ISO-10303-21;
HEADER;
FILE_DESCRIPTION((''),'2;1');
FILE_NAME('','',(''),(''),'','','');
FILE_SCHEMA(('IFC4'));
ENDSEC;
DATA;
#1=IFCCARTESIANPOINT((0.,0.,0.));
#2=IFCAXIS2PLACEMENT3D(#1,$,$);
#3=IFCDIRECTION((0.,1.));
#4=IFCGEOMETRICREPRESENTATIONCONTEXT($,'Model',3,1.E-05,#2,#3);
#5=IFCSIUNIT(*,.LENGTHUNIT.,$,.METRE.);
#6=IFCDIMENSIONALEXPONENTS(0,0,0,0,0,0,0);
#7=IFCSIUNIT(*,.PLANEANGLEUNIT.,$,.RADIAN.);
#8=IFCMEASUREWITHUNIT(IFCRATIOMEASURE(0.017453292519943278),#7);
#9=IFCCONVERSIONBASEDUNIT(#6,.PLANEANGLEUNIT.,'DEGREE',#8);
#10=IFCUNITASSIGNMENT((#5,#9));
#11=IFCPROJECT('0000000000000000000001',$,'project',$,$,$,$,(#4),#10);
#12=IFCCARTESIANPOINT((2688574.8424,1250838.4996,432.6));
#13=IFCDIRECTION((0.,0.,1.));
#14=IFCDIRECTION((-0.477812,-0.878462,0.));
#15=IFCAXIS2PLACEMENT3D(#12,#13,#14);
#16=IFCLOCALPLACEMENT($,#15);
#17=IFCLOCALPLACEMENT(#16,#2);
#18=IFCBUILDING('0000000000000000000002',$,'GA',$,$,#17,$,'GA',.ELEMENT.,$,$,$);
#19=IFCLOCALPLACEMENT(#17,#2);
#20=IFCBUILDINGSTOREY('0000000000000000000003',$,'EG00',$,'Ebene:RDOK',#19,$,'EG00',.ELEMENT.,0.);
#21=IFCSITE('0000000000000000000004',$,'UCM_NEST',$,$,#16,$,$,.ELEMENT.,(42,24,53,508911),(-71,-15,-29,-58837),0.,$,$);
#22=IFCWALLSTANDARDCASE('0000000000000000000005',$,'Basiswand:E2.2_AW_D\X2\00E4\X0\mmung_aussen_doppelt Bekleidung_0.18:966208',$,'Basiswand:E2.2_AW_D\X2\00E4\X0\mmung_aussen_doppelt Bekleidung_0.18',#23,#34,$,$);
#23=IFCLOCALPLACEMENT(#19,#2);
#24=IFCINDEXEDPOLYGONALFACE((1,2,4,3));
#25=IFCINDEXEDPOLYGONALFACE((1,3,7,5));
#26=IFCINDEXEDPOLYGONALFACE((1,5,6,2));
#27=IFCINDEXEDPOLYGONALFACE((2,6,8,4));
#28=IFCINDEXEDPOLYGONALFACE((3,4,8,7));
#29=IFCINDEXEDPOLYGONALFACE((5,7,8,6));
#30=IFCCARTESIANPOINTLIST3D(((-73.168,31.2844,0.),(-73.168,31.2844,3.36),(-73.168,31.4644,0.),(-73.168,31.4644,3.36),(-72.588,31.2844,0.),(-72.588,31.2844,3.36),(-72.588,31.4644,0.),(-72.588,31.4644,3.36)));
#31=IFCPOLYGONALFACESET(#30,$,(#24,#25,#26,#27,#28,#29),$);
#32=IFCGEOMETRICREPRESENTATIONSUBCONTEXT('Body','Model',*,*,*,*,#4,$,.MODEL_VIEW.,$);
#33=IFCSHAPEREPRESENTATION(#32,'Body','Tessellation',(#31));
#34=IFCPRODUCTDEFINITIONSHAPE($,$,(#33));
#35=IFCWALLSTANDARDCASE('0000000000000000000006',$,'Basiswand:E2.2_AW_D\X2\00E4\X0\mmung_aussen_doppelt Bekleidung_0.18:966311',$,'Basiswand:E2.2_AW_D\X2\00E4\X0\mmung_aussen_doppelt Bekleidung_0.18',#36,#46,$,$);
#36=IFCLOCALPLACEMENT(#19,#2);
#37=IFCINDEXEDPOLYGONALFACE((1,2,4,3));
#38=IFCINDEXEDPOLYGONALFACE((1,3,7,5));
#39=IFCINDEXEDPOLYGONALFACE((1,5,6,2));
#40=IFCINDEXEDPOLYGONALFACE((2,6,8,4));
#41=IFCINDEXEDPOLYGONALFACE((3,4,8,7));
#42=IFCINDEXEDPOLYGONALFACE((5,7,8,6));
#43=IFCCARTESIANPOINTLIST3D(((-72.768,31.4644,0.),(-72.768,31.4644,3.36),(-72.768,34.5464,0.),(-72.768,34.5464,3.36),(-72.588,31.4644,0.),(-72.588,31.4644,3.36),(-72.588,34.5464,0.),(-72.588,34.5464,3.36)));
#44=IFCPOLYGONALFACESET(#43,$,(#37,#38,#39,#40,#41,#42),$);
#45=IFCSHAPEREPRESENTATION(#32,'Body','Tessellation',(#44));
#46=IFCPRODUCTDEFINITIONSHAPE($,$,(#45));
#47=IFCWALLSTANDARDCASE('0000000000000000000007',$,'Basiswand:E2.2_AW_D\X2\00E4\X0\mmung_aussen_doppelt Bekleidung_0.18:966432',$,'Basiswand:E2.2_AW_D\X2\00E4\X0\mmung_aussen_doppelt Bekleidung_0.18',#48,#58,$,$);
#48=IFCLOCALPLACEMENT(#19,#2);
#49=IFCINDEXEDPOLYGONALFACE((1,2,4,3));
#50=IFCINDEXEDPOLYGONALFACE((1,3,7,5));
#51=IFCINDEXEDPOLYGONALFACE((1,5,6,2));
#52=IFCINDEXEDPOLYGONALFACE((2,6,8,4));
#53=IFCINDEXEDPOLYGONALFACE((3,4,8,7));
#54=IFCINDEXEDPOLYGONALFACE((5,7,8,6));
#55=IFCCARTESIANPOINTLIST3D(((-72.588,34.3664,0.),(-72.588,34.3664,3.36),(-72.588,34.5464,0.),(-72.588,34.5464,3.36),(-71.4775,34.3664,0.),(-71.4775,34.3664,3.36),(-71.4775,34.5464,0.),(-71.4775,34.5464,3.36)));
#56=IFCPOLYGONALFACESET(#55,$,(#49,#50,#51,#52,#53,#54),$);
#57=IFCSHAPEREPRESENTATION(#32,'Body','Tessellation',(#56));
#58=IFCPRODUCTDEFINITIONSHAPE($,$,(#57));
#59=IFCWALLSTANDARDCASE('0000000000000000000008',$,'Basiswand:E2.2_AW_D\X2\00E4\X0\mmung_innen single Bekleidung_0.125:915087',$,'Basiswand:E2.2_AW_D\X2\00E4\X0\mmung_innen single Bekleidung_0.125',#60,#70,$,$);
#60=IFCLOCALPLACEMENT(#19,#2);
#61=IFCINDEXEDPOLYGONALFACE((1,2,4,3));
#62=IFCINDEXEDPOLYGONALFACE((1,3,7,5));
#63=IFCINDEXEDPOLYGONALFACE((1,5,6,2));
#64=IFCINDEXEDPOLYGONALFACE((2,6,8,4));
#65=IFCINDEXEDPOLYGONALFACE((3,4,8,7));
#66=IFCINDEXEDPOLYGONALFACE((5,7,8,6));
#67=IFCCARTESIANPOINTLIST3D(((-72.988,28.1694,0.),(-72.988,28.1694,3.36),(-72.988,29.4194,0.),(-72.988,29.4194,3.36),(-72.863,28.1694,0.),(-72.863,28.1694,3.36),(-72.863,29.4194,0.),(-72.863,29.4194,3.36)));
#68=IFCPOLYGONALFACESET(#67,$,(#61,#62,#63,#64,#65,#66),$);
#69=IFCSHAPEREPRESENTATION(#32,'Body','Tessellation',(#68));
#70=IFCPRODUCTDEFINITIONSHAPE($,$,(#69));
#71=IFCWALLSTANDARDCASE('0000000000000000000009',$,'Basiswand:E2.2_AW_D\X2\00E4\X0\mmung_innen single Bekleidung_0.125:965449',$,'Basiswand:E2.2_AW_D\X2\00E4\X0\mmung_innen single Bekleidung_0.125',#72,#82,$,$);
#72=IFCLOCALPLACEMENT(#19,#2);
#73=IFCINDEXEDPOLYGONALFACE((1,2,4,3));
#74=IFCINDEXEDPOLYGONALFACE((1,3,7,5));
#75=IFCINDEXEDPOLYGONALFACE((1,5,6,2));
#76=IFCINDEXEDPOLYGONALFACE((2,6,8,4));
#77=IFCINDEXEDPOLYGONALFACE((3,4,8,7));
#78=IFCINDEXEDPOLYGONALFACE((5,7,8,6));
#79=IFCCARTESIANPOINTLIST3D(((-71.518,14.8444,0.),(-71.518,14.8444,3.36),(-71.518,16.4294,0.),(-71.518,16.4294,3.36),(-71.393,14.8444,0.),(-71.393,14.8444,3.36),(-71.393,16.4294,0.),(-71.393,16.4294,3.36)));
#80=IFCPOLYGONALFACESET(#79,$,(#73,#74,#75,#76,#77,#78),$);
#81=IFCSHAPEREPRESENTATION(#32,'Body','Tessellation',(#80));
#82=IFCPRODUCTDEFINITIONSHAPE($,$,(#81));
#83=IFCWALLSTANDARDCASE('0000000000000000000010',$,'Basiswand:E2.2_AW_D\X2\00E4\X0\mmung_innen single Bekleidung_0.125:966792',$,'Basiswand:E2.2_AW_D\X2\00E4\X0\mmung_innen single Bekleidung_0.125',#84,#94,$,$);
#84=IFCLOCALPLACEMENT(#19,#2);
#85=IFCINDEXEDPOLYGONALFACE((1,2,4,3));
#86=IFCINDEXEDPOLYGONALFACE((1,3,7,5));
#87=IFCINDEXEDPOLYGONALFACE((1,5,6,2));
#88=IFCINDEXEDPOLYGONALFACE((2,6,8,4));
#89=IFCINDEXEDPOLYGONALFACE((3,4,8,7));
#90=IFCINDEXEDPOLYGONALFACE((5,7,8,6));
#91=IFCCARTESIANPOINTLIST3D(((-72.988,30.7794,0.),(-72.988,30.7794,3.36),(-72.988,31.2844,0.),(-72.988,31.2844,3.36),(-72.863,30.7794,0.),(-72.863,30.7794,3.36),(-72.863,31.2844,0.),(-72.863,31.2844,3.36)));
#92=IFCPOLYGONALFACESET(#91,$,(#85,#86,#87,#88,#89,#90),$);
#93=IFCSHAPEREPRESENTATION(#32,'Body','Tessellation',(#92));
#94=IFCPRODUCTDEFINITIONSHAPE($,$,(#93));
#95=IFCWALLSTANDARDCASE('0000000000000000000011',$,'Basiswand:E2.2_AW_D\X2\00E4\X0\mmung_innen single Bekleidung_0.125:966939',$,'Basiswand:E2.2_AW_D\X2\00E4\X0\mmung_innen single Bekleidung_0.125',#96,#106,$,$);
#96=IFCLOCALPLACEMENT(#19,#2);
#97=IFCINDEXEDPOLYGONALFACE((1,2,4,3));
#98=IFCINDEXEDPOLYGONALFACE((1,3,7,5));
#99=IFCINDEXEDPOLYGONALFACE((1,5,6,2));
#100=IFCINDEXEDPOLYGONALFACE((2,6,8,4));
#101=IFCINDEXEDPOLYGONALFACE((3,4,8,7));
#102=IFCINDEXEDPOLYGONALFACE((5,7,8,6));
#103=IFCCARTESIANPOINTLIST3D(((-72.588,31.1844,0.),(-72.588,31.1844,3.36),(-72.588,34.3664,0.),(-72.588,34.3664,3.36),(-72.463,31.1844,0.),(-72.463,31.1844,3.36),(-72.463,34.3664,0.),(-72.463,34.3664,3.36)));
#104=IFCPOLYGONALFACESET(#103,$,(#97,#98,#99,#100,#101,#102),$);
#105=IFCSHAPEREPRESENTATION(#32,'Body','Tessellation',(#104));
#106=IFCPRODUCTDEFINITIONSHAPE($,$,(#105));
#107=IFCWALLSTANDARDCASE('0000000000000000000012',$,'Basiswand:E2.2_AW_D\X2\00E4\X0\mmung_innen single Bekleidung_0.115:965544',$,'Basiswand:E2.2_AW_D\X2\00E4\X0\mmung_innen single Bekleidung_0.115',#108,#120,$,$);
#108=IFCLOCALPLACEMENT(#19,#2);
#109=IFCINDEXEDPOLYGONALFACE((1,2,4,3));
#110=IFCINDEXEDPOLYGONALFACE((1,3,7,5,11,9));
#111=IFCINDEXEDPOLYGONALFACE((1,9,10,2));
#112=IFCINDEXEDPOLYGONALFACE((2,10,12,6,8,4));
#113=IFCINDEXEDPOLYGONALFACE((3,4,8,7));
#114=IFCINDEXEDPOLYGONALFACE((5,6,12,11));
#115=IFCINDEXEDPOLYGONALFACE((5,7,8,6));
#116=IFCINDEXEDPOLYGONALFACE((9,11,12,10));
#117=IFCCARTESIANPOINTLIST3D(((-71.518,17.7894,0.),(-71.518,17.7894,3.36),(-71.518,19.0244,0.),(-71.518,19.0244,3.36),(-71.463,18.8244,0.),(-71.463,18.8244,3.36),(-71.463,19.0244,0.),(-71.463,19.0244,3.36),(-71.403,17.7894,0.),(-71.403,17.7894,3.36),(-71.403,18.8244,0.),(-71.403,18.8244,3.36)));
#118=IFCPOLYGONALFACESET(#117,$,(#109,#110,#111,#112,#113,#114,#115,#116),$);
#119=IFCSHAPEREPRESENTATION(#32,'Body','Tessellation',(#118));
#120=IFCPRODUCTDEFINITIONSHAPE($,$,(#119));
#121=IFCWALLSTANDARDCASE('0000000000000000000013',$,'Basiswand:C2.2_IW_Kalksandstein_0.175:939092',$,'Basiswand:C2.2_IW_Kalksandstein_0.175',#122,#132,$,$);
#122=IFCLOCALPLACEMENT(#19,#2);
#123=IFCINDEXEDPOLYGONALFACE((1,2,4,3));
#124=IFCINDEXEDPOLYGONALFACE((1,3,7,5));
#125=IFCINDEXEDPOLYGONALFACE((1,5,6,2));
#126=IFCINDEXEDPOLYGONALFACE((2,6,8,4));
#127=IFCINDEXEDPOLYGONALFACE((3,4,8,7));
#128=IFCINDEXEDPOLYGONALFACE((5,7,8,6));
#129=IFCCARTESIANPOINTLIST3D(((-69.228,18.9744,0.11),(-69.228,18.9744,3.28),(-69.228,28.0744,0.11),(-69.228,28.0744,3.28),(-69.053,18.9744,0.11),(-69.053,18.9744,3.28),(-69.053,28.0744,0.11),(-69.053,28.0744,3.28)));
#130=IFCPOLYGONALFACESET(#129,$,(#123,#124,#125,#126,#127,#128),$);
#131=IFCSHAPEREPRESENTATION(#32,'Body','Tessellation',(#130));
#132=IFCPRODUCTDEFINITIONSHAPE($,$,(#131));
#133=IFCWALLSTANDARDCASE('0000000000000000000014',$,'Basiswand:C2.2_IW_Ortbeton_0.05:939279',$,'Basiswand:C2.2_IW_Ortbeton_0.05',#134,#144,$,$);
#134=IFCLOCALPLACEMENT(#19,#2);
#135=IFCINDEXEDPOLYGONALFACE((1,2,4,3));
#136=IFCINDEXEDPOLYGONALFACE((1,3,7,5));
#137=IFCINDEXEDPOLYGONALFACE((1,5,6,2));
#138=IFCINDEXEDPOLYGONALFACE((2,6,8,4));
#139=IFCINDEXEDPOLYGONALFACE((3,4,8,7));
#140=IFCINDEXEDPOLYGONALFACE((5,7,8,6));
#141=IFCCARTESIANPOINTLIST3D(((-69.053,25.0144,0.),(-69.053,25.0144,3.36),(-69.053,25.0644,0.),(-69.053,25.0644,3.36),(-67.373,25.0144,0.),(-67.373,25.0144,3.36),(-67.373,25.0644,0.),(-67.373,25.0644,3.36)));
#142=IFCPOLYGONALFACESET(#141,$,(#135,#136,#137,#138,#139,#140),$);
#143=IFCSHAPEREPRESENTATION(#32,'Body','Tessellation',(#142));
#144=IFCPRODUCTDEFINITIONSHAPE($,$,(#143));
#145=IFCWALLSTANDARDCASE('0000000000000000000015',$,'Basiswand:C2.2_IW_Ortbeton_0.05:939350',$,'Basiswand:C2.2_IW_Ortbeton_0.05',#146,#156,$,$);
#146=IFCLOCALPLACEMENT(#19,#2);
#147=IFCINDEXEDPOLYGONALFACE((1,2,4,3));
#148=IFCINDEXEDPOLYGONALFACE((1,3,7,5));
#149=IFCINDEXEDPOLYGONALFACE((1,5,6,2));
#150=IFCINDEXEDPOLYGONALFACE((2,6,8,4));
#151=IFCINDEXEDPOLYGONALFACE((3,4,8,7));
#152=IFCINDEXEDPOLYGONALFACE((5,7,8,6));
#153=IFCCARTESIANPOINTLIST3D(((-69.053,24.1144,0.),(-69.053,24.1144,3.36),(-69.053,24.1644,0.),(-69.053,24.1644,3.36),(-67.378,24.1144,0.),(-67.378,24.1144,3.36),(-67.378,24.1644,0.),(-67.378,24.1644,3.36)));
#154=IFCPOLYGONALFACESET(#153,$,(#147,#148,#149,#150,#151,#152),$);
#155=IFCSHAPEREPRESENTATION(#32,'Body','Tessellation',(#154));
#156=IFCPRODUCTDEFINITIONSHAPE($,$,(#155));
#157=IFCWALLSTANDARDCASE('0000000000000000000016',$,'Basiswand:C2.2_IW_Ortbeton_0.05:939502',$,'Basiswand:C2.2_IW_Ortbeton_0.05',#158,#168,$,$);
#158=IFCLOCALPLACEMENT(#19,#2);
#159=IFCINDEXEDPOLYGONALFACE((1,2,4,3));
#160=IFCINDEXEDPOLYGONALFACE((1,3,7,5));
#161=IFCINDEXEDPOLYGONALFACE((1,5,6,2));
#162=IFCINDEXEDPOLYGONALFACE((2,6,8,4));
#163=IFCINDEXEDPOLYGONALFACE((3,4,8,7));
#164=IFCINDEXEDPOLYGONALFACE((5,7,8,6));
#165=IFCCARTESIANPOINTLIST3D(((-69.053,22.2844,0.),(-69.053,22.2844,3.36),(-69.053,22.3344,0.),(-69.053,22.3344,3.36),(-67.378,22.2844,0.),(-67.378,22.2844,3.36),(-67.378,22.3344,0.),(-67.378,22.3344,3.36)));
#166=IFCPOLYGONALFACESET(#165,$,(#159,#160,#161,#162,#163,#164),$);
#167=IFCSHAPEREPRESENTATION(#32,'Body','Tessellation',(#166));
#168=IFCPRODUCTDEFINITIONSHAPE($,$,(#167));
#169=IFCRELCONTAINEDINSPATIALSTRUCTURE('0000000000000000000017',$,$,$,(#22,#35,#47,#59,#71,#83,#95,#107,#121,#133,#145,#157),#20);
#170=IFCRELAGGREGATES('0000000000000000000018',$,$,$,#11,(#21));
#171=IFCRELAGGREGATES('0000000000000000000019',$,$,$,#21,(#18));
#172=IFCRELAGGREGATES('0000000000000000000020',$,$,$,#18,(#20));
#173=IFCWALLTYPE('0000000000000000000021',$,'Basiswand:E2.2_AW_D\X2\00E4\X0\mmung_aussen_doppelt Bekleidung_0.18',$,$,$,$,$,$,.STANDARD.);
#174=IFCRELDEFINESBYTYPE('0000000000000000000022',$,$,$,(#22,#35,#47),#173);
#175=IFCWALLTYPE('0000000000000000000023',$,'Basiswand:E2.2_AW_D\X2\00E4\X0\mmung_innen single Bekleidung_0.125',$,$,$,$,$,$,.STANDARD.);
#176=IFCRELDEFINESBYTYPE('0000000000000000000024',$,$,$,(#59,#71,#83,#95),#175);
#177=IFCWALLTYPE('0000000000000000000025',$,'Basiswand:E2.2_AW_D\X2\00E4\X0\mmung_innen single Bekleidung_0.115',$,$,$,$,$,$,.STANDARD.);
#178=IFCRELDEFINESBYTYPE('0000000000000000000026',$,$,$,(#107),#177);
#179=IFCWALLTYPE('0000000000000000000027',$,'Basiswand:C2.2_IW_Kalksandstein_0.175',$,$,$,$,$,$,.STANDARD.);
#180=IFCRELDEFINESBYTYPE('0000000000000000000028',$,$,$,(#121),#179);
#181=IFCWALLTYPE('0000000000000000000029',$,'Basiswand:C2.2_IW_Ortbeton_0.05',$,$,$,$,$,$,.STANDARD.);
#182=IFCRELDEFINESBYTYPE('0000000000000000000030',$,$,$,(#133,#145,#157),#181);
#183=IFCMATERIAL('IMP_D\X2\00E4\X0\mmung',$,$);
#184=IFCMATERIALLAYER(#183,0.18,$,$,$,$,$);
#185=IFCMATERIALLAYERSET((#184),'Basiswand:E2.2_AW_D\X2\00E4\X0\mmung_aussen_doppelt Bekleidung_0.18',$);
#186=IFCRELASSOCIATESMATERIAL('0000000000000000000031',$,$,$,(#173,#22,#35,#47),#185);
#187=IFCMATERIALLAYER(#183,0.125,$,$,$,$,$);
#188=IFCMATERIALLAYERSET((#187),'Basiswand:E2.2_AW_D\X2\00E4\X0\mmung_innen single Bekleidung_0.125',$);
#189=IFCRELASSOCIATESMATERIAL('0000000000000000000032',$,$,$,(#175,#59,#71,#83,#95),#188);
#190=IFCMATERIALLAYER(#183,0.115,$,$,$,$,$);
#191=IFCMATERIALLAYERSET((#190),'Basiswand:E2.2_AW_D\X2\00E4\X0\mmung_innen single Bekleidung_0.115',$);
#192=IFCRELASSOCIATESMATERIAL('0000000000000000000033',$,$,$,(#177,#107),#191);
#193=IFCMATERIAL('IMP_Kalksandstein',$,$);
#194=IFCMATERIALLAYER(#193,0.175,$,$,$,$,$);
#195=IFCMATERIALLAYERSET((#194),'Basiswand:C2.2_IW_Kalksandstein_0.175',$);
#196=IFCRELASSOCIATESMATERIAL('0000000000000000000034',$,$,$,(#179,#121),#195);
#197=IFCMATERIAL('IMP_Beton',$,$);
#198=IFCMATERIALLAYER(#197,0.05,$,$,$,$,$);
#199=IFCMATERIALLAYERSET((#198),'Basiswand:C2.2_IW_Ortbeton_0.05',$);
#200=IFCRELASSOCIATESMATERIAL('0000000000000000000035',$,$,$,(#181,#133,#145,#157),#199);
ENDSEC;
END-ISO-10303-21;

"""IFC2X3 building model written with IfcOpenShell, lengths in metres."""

from ifc_helpers import new_model, entity, si_unit, converted_unit, direction, frame, frame_2d, origin, place, context, subcontext, project, spatial, polyline, rectangle, extrude, clip, bounded_halfspace, material, layer, layer_set, layer_usage, type_object, element, save


model = new_model("IFC2X3")

# Units and contexts
model_context = context("Model", 3, precision=1e-05, world=origin(), true_north=direction((0.0, 1.0)))
body_context = subcontext(model_context, "Body", "Model", "MODEL_VIEW")
ifc_project = project(units=[si_unit("LENGTHUNIT", "METRE"), converted_unit("PLANEANGLEUNIT", "DEGREE", entity("IfcRatioMeasure", 0.017453292519943278), si_unit("PLANEANGLEUNIT", "RADIAN"), dimensions=[0, 0, 0, 0, 0, 0, 0])], contexts=[model_context])

# Site, building, storey
site_placement = place(None, frame((2688574.8424, 1250838.4996, 432.6), z_axis=(0.0, 0.0, 1.0), x_axis=(-0.477812, -0.878462, 0.0)))
site = spatial("IfcSite", under=ifc_project, at=site_placement, Name="UCM_NEST", CompositionType="ELEMENT", RefLatitude=(42, 24, 53, 508911), RefLongitude=(-71, -15, -29, -58837), RefElevation=0.0)
building_placement = place(site_placement, origin())
building = spatial("IfcBuilding", under=site, at=building_placement, Name="GA", LongName="GA", CompositionType="ELEMENT")
storey_placement = place(building_placement, origin())
storey = spatial("IfcBuildingStorey", under=building, at=storey_placement, Name="EG00", ObjectType="Ebene:RDOK", LongName="EG00", CompositionType="ELEMENT", Elevation=0.0)

# Shared definitions
ifc_material_1 = material(Name="IMP_Beton")

# Shared definitions
ifc_material_2 = material(Name="IMP_Dämmung")
ifc_layer_1 = layer(ifc_material_2, 0.18)
ifc_layer_set_1 = layer_set([ifc_layer_1], Name="Basiswand:E2.2_AW_Dämmung_aussen_doppelt Bekleidung_0.18")
ifc_layer_usage_1 = layer_usage(ifc_layer_set_1, "AXIS2", "NEGATIVE", 0.09)
wall_type_1 = type_object("IfcWallType", Name="Basiswand:E2.2_AW_Dämmung_aussen_doppelt Bekleidung_0.18", PredefinedType="STANDARD", material=ifc_layer_set_1)

# Walls
wall_1_placement = place(storey_placement, frame((-73.168, 31.3744, 0.0)))
element("IfcWallStandardCase", 1, at=wall_1_placement, inside=storey, type_object=wall_type_1, material=ifc_layer_usage_1, Name="Basiswand:E2.2_AW_Dämmung_aussen_doppelt Bekleidung_0.18:966208", ObjectType="Basiswand:E2.2_AW_Dämmung_aussen_doppelt Bekleidung_0.18", context=body_context, shape_type="SweptSolid", body=[
    extrude(rectangle(XDim=0.58, YDim=0.18, at=frame_2d((0.29, 0.0), x_axis=(-1.0, 0.0))), origin(), (0.0, 0.0, 1.0), 3.36),
])
wall_2_placement = place(storey_placement, frame((-72.678, 31.4644, 0.0), z_axis=(0.0, 0.0, 1.0), x_axis=(0.0, 1.0, 0.0)))
element("IfcWallStandardCase", 2, at=wall_2_placement, inside=storey, type_object=wall_type_1, material=ifc_layer_usage_1, Name="Basiswand:E2.2_AW_Dämmung_aussen_doppelt Bekleidung_0.18:966311", ObjectType="Basiswand:E2.2_AW_Dämmung_aussen_doppelt Bekleidung_0.18", context=body_context, shape_type="SweptSolid", body=[
    extrude(rectangle(XDim=3.082, YDim=0.18, at=frame_2d((1.541, 0.0), x_axis=(-1.0, 0.0))), origin(), (0.0, 0.0, 1.0), 3.36),
])
wall_3_placement = place(storey_placement, frame((-72.588, 34.4564, 0.0)))
element("IfcWallStandardCase", 3, at=wall_3_placement, inside=storey, type_object=wall_type_1, material=ifc_layer_usage_1, Name="Basiswand:E2.2_AW_Dämmung_aussen_doppelt Bekleidung_0.18:966432", ObjectType="Basiswand:E2.2_AW_Dämmung_aussen_doppelt Bekleidung_0.18", context=body_context, shape_type="SweptSolid", body=[
    extrude(rectangle(XDim=1.1106, YDim=0.18, at=frame_2d((0.5553, 0.0), x_axis=(-1.0, 0.0))), origin(), (0.0, 0.0, 1.0), 3.36),
])
ifc_layer_2 = layer(ifc_material_2, 0.125)
ifc_layer_set_2 = layer_set([ifc_layer_2], Name="Basiswand:E2.2_AW_Dämmung_innen single Bekleidung_0.125")
ifc_layer_usage_2 = layer_usage(ifc_layer_set_2, "AXIS2", "NEGATIVE", 0.0625)
wall_type_2 = type_object("IfcWallType", Name="Basiswand:E2.2_AW_Dämmung_innen single Bekleidung_0.125", PredefinedType="STANDARD", material=ifc_layer_set_2)
wall_4_placement = place(storey_placement, frame((-72.9255, 28.1694, 0.0), z_axis=(0.0, 0.0, 1.0), x_axis=(0.0, 1.0, 0.0)))
element("IfcWallStandardCase", 4, at=wall_4_placement, inside=storey, type_object=wall_type_2, material=ifc_layer_usage_2, Name="Basiswand:E2.2_AW_Dämmung_innen single Bekleidung_0.125:915087", ObjectType="Basiswand:E2.2_AW_Dämmung_innen single Bekleidung_0.125", context=body_context, shape_type="SweptSolid", body=[
    extrude(rectangle(XDim=1.25, YDim=0.125, at=frame_2d((0.625, 0.0), x_axis=(-1.0, 0.0))), origin(), (0.0, 0.0, 1.0), 3.36),
])
wall_5_placement = place(storey_placement, frame((-71.4555, 14.8444, 0.0), z_axis=(0.0, 0.0, 1.0), x_axis=(0.0, 1.0, 0.0)))
element("IfcWallStandardCase", 5, at=wall_5_placement, inside=storey, type_object=wall_type_2, material=ifc_layer_usage_2, Name="Basiswand:E2.2_AW_Dämmung_innen single Bekleidung_0.125:965449", ObjectType="Basiswand:E2.2_AW_Dämmung_innen single Bekleidung_0.125", context=body_context, shape_type="SweptSolid", body=[
    extrude(rectangle(XDim=1.585, YDim=0.125, at=frame_2d((0.7925, 0.0), x_axis=(-1.0, 0.0))), origin(), (0.0, 0.0, 1.0), 3.36),
])
wall_6_placement = place(storey_placement, frame((-72.9255, 30.7794, 0.0), z_axis=(0.0, 0.0, 1.0), x_axis=(0.0, 1.0, 0.0)))
element("IfcWallStandardCase", 6, at=wall_6_placement, inside=storey, type_object=wall_type_2, material=ifc_layer_usage_2, Name="Basiswand:E2.2_AW_Dämmung_innen single Bekleidung_0.125:966792", ObjectType="Basiswand:E2.2_AW_Dämmung_innen single Bekleidung_0.125", context=body_context, shape_type="SweptSolid", body=[
    extrude(rectangle(XDim=0.505, YDim=0.125, at=frame_2d((0.2525, 0.0), x_axis=(-1.0, 0.0))), origin(), (0.0, 0.0, 1.0), 3.36),
])
wall_7_placement = place(storey_placement, frame((-72.5255, 31.1844, 0.0), z_axis=(0.0, 0.0, 1.0), x_axis=(0.0, 1.0, 0.0)))
element("IfcWallStandardCase", 7, at=wall_7_placement, inside=storey, type_object=wall_type_2, material=ifc_layer_usage_2, Name="Basiswand:E2.2_AW_Dämmung_innen single Bekleidung_0.125:966939", ObjectType="Basiswand:E2.2_AW_Dämmung_innen single Bekleidung_0.125", context=body_context, shape_type="Clipping", body=[
    clip(extrude(rectangle(XDim=3.182, YDim=0.125, at=frame_2d((1.591, 0.0), x_axis=(-1.0, 0.0))), origin(), (0.0, 0.0, 1.0), 3.36), bounded_halfspace(frame((0.0, -0.0625, 0.0), z_axis=(1.0, 0.0, 0.0), x_axis=(0.0, 1.0, 0.0)), True, frame((0.0, -0.0625, 0.0), z_axis=(1.0, 0.0, 0.0), x_axis=(0.0, 1.0, 0.0)), polyline([(0.0, 0.0), (0.125, 0.0), (0.125, 3.36), (0.0, 3.36), (0.0, 0.0)]))),
])

# Walls
ifc_layer_3 = layer(ifc_material_2, 0.115)
ifc_layer_set_3 = layer_set([ifc_layer_3], Name="Basiswand:E2.2_AW_Dämmung_innen single Bekleidung_0.115")
ifc_layer_usage_3 = layer_usage(ifc_layer_set_3, "AXIS2", "NEGATIVE", 0.0575)
wall_type_3 = type_object("IfcWallType", Name="Basiswand:E2.2_AW_Dämmung_innen single Bekleidung_0.115", PredefinedType="STANDARD", material=ifc_layer_set_3)
wall_8_placement = place(storey_placement, frame((-71.4605, 17.7894, 0.0), z_axis=(0.0, 0.0, 1.0), x_axis=(0.0, 1.0, 0.0)))
element("IfcWallStandardCase", 8, at=wall_8_placement, inside=storey, type_object=wall_type_3, material=ifc_layer_usage_3, Name="Basiswand:E2.2_AW_Dämmung_innen single Bekleidung_0.115:965544", ObjectType="Basiswand:E2.2_AW_Dämmung_innen single Bekleidung_0.115", context=body_context, shape_type="Clipping", body=[
    clip(clip(extrude(rectangle(XDim=1.235, YDim=0.115, at=frame_2d((0.6175, 0.0), x_axis=(-1.0, 0.0))), origin(), (0.0, 0.0, 1.0), 3.36), bounded_halfspace(frame((1.235, 0.0025, 0.0), z_axis=(0.0, 1.0, 0.0), x_axis=(-1.0, 0.0, 0.0)), True, frame((1.235, 0.0025, 0.0), z_axis=(0.0, 1.0, 0.0), x_axis=(-1.0, 0.0, 0.0)), polyline([(0.0, 0.0), (0.2, 0.0), (0.2, 3.36), (0.0, 3.36), (0.0, 0.0)]))), bounded_halfspace(frame((1.035, 0.0025, 0.0), z_axis=(-1.0, 0.0, 0.0), x_axis=(0.0, -1.0, 0.0)), True, frame((1.035, 0.0025, 0.0), z_axis=(-1.0, 0.0, 0.0), x_axis=(0.0, -1.0, 0.0)), polyline([(0.0, 0.0), (0.06, 0.0), (0.06, 3.36), (0.0, 3.36), (0.0, 0.0)]))),
])
ifc_material_3 = material(Name="IMP_Kalksandstein")
ifc_layer_4 = layer(ifc_material_3, 0.175)
ifc_layer_set_4 = layer_set([ifc_layer_4], Name="Basiswand:C2.2_IW_Kalksandstein_0.175")
ifc_layer_usage_4 = layer_usage(ifc_layer_set_4, "AXIS2", "NEGATIVE", 0.0875)
wall_type_4 = type_object("IfcWallType", Name="Basiswand:C2.2_IW_Kalksandstein_0.175", PredefinedType="STANDARD", material=ifc_layer_set_4)
wall_9_placement = place(storey_placement, frame((-69.1405, 28.0744, 0.11), z_axis=(0.0, 0.0, 1.0), x_axis=(0.0, -1.0, 0.0)))
element("IfcWallStandardCase", 9, at=wall_9_placement, inside=storey, type_object=wall_type_4, material=ifc_layer_usage_4, Name="Basiswand:C2.2_IW_Kalksandstein_0.175:939092", ObjectType="Basiswand:C2.2_IW_Kalksandstein_0.175", context=body_context, shape_type="Clipping", body=[
    clip(clip(extrude(rectangle(XDim=9.1, YDim=0.175, at=frame_2d((4.55, 0.0), x_axis=(-1.0, 0.0))), origin(), (0.0, 0.0, 1.0), 3.17), bounded_halfspace(frame((9.1, -0.0875, 0.0), z_axis=(0.0, 0.0, 1.0), x_axis=(0.0, -1.0, 0.0)), True, frame((9.1, -0.0875, 0.0), z_axis=(0.0, 0.0, 1.0), x_axis=(0.0, -1.0, 0.0)), polyline([(0.0, 0.0), (-0.175, 0.0), (-0.175, -9.1), (0.0, -9.1), (0.0, 0.0)]))), bounded_halfspace(frame((0.0, -0.0875, 3.17), z_axis=(0.0, 0.0, -1.0), x_axis=(0.0, -1.0, 0.0)), True, frame((0.0, -0.0875, 3.17), z_axis=(0.0, 0.0, -1.0), x_axis=(0.0, -1.0, 0.0)), polyline([(0.0, 0.0), (-0.175, 0.0), (-0.175, -9.1), (0.0, -9.1), (0.0, 0.0)]))),
])
ifc_layer_5 = layer(ifc_material_1, 0.05)
ifc_layer_set_5 = layer_set([ifc_layer_5], Name="Basiswand:C2.2_IW_Ortbeton_0.05")
ifc_layer_usage_5 = layer_usage(ifc_layer_set_5, "AXIS2", "NEGATIVE", 0.025)
wall_type_5 = type_object("IfcWallType", Name="Basiswand:C2.2_IW_Ortbeton_0.05", PredefinedType="STANDARD", material=ifc_layer_set_5)
wall_10_placement = place(storey_placement, frame((-69.053, 25.0394, 0.0)))
element("IfcWallStandardCase", 10, at=wall_10_placement, inside=storey, type_object=wall_type_5, material=ifc_layer_usage_5, Name="Basiswand:C2.2_IW_Ortbeton_0.05:939279", ObjectType="Basiswand:C2.2_IW_Ortbeton_0.05", context=body_context, shape_type="SweptSolid", body=[
    extrude(rectangle(XDim=1.68, YDim=0.05, at=frame_2d((0.84, 0.0), x_axis=(-1.0, 0.0))), origin(), (0.0, 0.0, 1.0), 3.36),
])
wall_11_placement = place(storey_placement, frame((-69.053, 24.1394, 0.0)))
element("IfcWallStandardCase", 11, at=wall_11_placement, inside=storey, type_object=wall_type_5, material=ifc_layer_usage_5, Name="Basiswand:C2.2_IW_Ortbeton_0.05:939350", ObjectType="Basiswand:C2.2_IW_Ortbeton_0.05", context=body_context, shape_type="SweptSolid", body=[
    extrude(rectangle(XDim=1.675, YDim=0.05, at=frame_2d((0.8375, 0.0), x_axis=(-1.0, 0.0))), origin(), (0.0, 0.0, 1.0), 3.36),
])
wall_12_placement = place(storey_placement, frame((-69.053, 22.3094, 0.0)))
element("IfcWallStandardCase", 12, at=wall_12_placement, inside=storey, type_object=wall_type_5, material=ifc_layer_usage_5, Name="Basiswand:C2.2_IW_Ortbeton_0.05:939502", ObjectType="Basiswand:C2.2_IW_Ortbeton_0.05", context=body_context, shape_type="SweptSolid", body=[
    extrude(rectangle(XDim=1.675, YDim=0.05, at=frame_2d((0.8375, 0.0), x_axis=(-1.0, 0.0))), origin(), (0.0, 0.0, 1.0), 3.36),
])

save(model, "model.ifc")
